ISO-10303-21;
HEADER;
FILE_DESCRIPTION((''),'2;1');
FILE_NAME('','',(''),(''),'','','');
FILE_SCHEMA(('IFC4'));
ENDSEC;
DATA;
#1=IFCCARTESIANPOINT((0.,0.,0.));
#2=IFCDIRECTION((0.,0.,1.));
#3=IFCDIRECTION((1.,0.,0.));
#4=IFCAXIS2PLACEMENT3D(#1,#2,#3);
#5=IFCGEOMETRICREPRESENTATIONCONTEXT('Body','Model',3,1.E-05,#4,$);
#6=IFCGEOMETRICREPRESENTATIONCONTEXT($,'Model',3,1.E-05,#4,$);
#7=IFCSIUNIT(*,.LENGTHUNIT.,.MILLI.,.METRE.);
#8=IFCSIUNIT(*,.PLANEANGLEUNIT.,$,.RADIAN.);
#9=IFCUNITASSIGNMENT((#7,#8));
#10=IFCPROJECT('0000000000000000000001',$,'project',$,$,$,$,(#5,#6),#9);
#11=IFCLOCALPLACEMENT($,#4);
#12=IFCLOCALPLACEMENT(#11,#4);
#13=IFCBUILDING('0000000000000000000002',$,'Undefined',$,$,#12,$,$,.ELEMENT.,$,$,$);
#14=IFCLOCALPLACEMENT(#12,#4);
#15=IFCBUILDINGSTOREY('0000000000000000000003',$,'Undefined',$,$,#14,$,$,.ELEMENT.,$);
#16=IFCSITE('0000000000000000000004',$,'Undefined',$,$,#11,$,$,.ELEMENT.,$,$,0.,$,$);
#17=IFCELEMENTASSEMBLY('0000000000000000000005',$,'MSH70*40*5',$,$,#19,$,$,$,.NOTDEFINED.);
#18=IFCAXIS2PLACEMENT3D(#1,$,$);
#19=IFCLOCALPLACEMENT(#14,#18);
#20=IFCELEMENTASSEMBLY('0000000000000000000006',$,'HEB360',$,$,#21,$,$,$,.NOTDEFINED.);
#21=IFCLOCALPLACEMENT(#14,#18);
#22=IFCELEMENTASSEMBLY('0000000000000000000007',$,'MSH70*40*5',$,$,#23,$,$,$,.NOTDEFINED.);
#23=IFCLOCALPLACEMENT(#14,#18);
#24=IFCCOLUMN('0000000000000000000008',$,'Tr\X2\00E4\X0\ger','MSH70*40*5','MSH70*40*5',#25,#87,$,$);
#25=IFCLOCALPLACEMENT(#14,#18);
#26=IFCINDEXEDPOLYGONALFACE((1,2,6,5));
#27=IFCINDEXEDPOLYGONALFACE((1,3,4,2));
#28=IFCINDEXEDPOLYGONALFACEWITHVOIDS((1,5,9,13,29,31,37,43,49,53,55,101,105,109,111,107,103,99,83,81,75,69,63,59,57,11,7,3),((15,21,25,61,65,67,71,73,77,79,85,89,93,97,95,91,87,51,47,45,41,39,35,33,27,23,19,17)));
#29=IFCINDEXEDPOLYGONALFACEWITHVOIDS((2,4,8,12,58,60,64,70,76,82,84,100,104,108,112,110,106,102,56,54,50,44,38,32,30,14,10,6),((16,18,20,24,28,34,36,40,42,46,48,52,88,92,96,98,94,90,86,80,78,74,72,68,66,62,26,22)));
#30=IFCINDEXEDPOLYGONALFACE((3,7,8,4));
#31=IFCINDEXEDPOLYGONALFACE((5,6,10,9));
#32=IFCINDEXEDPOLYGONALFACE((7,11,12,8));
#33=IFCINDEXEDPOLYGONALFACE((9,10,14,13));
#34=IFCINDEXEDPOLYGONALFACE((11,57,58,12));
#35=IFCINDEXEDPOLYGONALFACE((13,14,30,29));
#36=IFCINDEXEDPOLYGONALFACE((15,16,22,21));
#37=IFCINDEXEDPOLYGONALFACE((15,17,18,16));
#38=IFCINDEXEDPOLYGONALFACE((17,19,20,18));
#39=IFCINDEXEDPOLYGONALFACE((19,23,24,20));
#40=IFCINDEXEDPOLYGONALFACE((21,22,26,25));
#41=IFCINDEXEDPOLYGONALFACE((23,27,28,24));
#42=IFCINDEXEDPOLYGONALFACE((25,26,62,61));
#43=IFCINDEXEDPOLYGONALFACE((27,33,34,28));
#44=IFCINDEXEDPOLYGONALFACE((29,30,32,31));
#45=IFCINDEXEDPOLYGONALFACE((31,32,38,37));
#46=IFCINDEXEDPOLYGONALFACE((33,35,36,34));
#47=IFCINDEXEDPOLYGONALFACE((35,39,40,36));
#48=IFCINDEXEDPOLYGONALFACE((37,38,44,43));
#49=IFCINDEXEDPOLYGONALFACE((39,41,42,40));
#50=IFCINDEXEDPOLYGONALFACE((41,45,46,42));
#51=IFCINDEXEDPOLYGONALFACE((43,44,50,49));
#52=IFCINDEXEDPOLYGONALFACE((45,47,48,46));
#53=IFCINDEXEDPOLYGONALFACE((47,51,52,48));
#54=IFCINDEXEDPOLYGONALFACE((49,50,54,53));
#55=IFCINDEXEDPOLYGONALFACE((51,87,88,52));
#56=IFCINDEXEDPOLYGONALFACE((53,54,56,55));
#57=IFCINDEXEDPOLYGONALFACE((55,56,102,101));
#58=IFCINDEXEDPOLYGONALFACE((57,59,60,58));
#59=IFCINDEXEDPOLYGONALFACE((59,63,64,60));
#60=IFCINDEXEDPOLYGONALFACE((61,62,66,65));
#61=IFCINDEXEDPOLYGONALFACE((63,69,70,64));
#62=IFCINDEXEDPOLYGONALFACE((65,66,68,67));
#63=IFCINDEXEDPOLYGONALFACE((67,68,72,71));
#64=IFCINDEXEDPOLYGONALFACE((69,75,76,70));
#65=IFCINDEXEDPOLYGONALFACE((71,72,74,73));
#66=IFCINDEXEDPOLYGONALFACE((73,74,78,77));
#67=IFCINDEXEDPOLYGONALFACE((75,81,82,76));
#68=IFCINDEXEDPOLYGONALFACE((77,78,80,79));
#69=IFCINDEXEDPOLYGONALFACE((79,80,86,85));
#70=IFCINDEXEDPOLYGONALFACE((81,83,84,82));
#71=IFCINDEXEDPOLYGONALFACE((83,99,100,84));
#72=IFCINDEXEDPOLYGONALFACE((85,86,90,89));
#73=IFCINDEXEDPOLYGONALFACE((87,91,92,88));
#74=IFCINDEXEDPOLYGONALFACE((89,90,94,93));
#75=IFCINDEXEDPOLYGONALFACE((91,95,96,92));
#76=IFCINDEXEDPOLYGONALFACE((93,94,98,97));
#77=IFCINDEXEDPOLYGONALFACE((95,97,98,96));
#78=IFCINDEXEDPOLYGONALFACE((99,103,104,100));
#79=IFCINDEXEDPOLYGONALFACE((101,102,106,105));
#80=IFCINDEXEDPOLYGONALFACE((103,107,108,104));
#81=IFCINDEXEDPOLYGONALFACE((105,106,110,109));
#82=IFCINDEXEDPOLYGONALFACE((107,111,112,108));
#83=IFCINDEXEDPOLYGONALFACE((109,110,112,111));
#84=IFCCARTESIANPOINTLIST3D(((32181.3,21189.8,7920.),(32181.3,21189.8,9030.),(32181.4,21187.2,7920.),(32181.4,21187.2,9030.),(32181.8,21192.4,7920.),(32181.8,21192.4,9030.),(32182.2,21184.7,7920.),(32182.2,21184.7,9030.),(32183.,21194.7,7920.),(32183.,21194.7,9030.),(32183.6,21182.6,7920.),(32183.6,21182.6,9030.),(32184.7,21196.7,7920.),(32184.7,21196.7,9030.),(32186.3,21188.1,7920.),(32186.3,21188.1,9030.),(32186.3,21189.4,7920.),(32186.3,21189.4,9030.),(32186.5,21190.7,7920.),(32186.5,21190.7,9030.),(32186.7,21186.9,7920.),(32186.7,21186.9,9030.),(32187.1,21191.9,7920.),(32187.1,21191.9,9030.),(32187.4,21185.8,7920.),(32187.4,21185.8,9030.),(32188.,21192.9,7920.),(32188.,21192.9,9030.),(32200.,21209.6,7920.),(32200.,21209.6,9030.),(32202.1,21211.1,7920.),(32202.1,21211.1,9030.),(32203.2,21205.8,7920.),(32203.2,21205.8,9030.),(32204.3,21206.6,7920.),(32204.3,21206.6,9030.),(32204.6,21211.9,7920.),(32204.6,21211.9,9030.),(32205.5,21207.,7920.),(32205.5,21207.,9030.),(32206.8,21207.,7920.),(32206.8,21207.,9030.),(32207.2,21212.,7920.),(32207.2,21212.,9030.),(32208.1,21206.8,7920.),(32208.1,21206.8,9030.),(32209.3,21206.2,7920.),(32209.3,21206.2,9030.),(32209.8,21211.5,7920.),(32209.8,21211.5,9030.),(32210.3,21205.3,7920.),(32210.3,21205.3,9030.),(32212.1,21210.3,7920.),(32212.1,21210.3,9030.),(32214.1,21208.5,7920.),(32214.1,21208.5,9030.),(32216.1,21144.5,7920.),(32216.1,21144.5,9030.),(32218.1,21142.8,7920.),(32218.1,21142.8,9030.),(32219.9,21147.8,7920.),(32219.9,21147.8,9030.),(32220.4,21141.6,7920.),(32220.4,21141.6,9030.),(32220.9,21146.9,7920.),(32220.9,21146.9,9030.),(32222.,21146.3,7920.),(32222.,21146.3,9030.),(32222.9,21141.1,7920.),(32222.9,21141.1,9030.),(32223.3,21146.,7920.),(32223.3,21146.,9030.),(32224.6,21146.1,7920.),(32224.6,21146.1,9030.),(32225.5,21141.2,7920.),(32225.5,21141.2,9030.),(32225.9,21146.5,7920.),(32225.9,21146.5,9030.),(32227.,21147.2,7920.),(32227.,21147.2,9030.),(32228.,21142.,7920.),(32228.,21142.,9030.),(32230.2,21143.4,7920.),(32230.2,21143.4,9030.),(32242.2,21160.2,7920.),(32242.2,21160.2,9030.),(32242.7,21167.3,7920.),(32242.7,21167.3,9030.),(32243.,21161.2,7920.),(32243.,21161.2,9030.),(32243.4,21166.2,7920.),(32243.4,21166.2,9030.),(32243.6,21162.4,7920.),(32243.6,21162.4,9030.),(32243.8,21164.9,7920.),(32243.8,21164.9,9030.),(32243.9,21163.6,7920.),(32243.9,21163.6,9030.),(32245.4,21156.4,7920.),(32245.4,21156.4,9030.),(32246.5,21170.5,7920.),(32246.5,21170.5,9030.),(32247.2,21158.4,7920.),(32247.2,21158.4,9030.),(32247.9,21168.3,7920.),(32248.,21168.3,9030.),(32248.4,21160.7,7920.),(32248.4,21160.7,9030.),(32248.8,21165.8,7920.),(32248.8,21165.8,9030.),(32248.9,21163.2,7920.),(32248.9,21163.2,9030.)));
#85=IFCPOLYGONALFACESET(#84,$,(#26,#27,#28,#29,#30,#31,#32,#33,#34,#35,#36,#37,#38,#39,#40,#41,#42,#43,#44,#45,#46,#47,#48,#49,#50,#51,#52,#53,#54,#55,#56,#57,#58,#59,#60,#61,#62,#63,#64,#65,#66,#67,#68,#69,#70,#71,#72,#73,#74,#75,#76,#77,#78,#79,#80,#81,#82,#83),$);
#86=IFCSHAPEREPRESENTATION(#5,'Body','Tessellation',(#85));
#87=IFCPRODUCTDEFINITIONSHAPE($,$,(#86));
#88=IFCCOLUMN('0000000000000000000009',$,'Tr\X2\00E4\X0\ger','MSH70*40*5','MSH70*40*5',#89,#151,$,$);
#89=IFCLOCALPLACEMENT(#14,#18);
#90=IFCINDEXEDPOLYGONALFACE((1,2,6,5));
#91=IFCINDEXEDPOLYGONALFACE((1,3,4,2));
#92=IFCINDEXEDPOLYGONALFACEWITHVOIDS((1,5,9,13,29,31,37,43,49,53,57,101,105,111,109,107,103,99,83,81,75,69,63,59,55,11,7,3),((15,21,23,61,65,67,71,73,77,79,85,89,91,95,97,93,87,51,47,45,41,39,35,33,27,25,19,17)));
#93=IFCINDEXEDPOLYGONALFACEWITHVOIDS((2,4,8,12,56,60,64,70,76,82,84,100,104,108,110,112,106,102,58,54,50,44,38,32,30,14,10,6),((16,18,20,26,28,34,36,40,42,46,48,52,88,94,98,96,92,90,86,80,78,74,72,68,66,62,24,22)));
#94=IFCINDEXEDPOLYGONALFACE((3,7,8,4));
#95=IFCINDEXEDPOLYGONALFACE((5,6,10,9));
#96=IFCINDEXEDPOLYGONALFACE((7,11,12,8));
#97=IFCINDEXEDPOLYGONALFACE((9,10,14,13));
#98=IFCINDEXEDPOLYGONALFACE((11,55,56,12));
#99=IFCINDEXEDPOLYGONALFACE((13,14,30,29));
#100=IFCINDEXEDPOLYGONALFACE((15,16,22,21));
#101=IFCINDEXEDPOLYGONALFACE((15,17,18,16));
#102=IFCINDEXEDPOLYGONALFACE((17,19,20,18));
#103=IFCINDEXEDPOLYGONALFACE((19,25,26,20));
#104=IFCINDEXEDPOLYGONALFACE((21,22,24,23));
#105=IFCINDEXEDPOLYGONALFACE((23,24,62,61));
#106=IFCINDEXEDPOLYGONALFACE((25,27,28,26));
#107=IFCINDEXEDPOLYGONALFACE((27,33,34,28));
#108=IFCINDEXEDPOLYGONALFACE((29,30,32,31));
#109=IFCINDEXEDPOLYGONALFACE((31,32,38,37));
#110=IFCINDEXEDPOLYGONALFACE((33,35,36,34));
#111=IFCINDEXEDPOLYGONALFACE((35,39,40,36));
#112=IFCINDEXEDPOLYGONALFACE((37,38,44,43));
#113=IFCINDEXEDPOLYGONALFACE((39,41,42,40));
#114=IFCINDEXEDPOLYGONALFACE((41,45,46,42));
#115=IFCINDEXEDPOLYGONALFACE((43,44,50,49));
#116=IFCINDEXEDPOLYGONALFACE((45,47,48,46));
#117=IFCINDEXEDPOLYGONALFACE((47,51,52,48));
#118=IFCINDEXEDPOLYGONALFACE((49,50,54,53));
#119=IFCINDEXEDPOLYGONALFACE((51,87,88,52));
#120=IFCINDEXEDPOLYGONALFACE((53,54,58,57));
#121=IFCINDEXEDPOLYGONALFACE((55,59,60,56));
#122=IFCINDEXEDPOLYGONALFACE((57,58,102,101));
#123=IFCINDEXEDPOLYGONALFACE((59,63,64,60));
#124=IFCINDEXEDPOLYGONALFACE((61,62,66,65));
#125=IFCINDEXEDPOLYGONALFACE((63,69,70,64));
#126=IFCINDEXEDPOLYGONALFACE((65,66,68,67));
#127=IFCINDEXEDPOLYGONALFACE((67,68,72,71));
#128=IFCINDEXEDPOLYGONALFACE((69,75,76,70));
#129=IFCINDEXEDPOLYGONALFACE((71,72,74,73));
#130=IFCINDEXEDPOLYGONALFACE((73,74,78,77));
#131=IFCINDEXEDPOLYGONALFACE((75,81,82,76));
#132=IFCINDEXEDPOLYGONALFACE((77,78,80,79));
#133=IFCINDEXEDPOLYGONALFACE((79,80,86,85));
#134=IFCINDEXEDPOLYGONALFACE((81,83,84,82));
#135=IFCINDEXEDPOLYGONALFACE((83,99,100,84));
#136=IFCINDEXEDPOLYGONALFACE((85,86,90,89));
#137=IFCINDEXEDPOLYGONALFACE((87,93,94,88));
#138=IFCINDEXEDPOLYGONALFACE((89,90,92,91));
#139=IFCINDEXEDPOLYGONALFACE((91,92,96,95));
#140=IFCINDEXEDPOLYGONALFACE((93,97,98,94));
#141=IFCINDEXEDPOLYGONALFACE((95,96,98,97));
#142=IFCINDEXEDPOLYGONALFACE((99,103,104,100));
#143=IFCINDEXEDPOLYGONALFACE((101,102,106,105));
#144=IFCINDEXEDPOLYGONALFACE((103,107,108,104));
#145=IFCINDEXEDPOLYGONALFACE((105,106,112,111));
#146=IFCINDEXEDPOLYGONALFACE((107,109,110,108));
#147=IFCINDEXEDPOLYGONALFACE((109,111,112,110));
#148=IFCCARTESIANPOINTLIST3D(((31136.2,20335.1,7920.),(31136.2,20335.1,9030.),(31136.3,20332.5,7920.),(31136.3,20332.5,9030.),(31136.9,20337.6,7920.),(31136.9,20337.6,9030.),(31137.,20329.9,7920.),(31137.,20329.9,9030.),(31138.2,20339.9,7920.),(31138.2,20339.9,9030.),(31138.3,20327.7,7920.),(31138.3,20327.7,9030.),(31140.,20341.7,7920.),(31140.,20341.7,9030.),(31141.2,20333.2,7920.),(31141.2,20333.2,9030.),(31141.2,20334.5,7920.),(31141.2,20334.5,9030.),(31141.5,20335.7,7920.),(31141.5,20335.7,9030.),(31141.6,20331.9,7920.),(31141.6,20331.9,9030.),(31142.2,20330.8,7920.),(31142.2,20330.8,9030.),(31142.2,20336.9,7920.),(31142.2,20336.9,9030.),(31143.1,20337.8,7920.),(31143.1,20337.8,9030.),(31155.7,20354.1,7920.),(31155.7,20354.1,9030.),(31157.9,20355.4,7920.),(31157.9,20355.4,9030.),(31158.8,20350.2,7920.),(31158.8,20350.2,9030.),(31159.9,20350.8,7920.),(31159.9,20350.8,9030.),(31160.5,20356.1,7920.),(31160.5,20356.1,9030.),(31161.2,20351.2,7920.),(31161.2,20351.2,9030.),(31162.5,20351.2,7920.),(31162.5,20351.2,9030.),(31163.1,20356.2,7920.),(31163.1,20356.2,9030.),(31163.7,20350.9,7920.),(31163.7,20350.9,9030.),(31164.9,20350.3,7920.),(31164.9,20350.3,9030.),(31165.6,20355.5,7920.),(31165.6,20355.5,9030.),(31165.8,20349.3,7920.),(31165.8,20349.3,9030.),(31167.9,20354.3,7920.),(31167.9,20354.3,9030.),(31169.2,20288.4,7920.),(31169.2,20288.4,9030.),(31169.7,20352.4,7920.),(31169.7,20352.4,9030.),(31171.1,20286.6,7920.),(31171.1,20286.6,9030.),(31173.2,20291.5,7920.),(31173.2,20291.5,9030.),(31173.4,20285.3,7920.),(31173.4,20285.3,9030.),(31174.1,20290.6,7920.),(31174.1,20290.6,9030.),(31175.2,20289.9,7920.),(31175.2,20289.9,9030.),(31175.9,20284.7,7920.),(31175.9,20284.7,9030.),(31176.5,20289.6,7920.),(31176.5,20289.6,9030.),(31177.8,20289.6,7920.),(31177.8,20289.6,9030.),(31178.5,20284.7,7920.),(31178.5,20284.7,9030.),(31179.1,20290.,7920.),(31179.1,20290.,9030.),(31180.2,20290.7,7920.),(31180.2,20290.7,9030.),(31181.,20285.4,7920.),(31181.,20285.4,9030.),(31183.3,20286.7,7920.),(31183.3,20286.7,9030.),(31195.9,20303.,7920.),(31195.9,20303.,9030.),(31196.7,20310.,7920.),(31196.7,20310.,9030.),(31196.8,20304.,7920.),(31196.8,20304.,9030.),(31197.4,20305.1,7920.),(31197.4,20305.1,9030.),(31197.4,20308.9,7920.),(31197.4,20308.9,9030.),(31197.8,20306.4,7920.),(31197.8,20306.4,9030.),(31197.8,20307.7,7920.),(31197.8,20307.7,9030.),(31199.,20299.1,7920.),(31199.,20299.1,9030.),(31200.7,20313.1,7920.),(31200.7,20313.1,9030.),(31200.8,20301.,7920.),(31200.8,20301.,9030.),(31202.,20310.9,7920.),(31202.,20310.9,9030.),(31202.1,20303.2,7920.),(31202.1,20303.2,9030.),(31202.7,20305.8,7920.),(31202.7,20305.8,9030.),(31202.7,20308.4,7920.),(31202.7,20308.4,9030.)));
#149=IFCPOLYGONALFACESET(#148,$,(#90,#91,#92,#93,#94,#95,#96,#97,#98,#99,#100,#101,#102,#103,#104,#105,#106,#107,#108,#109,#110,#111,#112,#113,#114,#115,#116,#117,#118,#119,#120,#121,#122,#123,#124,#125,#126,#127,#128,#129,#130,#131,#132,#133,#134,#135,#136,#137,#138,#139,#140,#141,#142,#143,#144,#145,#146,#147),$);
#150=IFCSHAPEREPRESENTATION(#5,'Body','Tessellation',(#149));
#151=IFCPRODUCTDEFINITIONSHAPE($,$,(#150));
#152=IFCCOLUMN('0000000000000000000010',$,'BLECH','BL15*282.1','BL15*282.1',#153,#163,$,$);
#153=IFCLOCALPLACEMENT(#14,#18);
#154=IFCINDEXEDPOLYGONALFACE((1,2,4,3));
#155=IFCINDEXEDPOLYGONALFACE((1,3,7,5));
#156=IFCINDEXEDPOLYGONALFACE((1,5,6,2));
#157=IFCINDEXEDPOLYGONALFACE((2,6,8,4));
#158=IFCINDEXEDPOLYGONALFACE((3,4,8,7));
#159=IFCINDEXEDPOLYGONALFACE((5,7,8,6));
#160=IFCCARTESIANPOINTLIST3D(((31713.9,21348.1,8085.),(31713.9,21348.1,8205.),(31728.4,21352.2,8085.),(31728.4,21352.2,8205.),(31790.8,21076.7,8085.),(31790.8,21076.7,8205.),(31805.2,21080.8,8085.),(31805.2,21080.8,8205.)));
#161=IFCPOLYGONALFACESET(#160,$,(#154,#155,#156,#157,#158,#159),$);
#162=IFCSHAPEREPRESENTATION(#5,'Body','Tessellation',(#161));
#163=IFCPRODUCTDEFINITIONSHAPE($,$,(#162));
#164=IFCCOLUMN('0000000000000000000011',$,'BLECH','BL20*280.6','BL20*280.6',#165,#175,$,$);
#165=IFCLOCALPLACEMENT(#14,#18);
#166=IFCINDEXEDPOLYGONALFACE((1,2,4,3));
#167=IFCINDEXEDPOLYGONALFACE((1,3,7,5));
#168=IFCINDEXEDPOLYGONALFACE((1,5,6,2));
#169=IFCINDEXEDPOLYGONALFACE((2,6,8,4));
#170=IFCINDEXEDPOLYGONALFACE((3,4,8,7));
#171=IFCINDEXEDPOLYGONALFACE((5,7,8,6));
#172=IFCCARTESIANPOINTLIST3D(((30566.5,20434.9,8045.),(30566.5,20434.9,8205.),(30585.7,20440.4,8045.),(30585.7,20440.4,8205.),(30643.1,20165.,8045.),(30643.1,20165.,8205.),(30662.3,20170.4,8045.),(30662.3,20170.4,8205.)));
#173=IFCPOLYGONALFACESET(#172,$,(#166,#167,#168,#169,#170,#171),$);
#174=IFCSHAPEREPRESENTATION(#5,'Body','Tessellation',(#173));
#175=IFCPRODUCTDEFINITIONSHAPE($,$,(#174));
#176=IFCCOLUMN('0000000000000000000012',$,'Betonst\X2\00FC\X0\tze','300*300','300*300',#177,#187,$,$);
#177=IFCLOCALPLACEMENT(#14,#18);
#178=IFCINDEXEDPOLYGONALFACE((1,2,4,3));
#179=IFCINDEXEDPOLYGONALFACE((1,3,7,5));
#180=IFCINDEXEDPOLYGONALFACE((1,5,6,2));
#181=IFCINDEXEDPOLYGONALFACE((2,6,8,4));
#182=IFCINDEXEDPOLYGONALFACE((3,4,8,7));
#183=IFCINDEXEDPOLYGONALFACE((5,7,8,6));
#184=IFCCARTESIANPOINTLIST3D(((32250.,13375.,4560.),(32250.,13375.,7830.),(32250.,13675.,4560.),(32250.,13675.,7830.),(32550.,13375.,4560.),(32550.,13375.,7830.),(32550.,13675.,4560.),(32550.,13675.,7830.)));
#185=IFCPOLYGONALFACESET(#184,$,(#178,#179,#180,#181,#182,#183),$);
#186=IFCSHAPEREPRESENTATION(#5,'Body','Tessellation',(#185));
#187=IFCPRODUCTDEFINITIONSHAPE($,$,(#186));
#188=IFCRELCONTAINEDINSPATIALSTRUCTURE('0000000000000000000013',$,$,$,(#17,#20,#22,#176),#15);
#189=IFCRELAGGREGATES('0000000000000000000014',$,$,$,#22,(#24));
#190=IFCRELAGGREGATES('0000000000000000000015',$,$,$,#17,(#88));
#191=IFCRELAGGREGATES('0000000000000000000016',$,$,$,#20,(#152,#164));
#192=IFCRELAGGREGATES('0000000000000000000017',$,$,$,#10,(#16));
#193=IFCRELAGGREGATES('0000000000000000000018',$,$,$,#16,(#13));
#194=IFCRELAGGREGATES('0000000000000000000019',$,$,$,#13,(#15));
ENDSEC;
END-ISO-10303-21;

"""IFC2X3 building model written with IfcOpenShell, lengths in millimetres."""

from ifc_helpers import new_model, si_unit, frame, origin_with_axes, origin_2d_with_axis, place, context, project, spatial, rectangle, hollow_rectangle, extrude, element, aggregate, save


model = new_model("IFC2X3")

# Units and contexts
model_context_1 = context("Model", 3, precision=1e-05, world=origin_with_axes(), identifier="Body")
model_context_2 = context("Model", 3, precision=1e-05, world=origin_with_axes())
ifc_project = project(units=[si_unit("LENGTHUNIT", "METRE", prefix="MILLI"), si_unit("PLANEANGLEUNIT", "RADIAN")], contexts=[model_context_1, model_context_2])

# Site, building, storey
site_placement = place(None, origin_with_axes())
site = spatial("IfcSite", under=ifc_project, at=site_placement, Name="Undefined", CompositionType="ELEMENT", RefElevation=0.0)
building_placement = place(site_placement, origin_with_axes())
building = spatial("IfcBuilding", under=site, at=building_placement, Name="Undefined", CompositionType="ELEMENT")
storey_placement = place(building_placement, origin_with_axes())
storey = spatial("IfcBuildingStorey", under=building, at=storey_placement, Name="Undefined", CompositionType="ELEMENT")

# Element assembly
assembly_1 = element("IfcElementAssembly", 1, inside=storey, Name="MSH70*40*5", PredefinedType="NOTDEFINED")

# Element assembly
assembly_2 = element("IfcElementAssembly", 2, inside=storey, Name="HEB360", PredefinedType="NOTDEFINED")

# Element assembly
assembly_3 = element("IfcElementAssembly", 3, inside=storey, Name="MSH70*40*5", PredefinedType="NOTDEFINED")

# Columns
column_1_placement = place(storey_placement, frame((32215.1, 21176.5, 7920.0), z_axis=(0.0, 0.0, 1.0), x_axis=(1.0, 0.0, 0.0)))
column_1 = element("IfcColumn", 4, at=column_1_placement, Name="Träger", Description="MSH70*40*5", ObjectType="MSH70*40*5", context=model_context_1, shape_type="SweptSolid", body=[
    extrude(hollow_rectangle(XDim=40.0, YDim=70.0, WallThickness=5.0, InnerFilletRadius=5.0, OuterFilletRadius=10.0, at=origin_2d_with_axis()), frame((0.0, 0.0, 1110.0), z_axis=(0.0, 0.0, -1.0), x_axis=(-0.760406, -0.649448, 0.000005)), (0.0, 0.0, 1.0), 1110.0),
])
aggregate(assembly_3, [column_1])
column_2_placement = place(storey_placement, frame((31169.5, 20320.4, 7920.0), z_axis=(0.0, 0.0, 1.0), x_axis=(1.0, 0.0, 0.0)))
column_2 = element("IfcColumn", 5, at=column_2_placement, Name="Träger", Description="MSH70*40*5", ObjectType="MSH70*40*5", context=model_context_1, shape_type="SweptSolid", body=[
    extrude(hollow_rectangle(XDim=40.0, YDim=70.0, WallThickness=5.0, InnerFilletRadius=5.0, OuterFilletRadius=10.0, at=origin_2d_with_axis()), frame((0.0, 0.0, 1110.0), z_axis=(0.0, 0.0, -1.0), x_axis=(-0.785857, -0.618409, 0.000005)), (0.0, 0.0, 1.0), 1110.0),
])
aggregate(assembly_1, [column_2])
column_3_placement = place(storey_placement, frame((31759.6, 21214.4, 8085.0), z_axis=(0.0, 0.0, 1.0), x_axis=(1.0, 0.0, 0.0)))
column_3 = element("IfcColumn", 6, at=column_3_placement, Name="BLECH", Description="BL15*282.1", ObjectType="BL15*282.1", context=model_context_1, shape_type="SweptSolid", body=[
    extrude(rectangle(XDim=15.0, YDim=282.1, at=origin_2d_with_axis()), frame((0.0, 0.0, 120.0), z_axis=(0.0, 0.0, -1.0), x_axis=(0.96217, 0.272448, 0.0)), (0.0, 0.0, 1.0), 120.0),
])
column_4_placement = place(storey_placement, frame((30614.4, 20302.7, 8045.0), z_axis=(0.0, 0.0, 1.0), x_axis=(1.0, 0.0, 0.0)))
column_4 = element("IfcColumn", 7, at=column_4_placement, Name="BLECH", Description="BL20*280.6", ObjectType="BL20*280.6", context=model_context_1, shape_type="SweptSolid", body=[
    extrude(rectangle(XDim=20.0, YDim=280.6, at=origin_2d_with_axis()), frame((0.0, 0.0, 160.0), z_axis=(0.0, 0.0, -1.0), x_axis=(0.96203, 0.272943, 0.0)), (0.0, 0.0, 1.0), 160.0),
])
aggregate(assembly_2, [column_3, column_4])

# Column
column_5_placement = place(storey_placement, frame((32400.0, 13525.0, 4560.0), z_axis=(0.0, 0.0, 1.0), x_axis=(1.0, 0.0, 0.0)))
element("IfcColumn", 8, at=column_5_placement, inside=storey, Name="Betonstütze", Description="300*300", ObjectType="300*300", context=model_context_1, shape_type="SweptSolid", body=[
    extrude(rectangle(XDim=300.0, YDim=300.0, at=origin_2d_with_axis()), frame((0.0, 0.0, 3270.0), z_axis=(0.0, 0.0, -1.0), x_axis=(1.0, 0.0, 0.0)), (0.0, 0.0, 1.0), 3270.0),
])

save(model, "model.ifc")
